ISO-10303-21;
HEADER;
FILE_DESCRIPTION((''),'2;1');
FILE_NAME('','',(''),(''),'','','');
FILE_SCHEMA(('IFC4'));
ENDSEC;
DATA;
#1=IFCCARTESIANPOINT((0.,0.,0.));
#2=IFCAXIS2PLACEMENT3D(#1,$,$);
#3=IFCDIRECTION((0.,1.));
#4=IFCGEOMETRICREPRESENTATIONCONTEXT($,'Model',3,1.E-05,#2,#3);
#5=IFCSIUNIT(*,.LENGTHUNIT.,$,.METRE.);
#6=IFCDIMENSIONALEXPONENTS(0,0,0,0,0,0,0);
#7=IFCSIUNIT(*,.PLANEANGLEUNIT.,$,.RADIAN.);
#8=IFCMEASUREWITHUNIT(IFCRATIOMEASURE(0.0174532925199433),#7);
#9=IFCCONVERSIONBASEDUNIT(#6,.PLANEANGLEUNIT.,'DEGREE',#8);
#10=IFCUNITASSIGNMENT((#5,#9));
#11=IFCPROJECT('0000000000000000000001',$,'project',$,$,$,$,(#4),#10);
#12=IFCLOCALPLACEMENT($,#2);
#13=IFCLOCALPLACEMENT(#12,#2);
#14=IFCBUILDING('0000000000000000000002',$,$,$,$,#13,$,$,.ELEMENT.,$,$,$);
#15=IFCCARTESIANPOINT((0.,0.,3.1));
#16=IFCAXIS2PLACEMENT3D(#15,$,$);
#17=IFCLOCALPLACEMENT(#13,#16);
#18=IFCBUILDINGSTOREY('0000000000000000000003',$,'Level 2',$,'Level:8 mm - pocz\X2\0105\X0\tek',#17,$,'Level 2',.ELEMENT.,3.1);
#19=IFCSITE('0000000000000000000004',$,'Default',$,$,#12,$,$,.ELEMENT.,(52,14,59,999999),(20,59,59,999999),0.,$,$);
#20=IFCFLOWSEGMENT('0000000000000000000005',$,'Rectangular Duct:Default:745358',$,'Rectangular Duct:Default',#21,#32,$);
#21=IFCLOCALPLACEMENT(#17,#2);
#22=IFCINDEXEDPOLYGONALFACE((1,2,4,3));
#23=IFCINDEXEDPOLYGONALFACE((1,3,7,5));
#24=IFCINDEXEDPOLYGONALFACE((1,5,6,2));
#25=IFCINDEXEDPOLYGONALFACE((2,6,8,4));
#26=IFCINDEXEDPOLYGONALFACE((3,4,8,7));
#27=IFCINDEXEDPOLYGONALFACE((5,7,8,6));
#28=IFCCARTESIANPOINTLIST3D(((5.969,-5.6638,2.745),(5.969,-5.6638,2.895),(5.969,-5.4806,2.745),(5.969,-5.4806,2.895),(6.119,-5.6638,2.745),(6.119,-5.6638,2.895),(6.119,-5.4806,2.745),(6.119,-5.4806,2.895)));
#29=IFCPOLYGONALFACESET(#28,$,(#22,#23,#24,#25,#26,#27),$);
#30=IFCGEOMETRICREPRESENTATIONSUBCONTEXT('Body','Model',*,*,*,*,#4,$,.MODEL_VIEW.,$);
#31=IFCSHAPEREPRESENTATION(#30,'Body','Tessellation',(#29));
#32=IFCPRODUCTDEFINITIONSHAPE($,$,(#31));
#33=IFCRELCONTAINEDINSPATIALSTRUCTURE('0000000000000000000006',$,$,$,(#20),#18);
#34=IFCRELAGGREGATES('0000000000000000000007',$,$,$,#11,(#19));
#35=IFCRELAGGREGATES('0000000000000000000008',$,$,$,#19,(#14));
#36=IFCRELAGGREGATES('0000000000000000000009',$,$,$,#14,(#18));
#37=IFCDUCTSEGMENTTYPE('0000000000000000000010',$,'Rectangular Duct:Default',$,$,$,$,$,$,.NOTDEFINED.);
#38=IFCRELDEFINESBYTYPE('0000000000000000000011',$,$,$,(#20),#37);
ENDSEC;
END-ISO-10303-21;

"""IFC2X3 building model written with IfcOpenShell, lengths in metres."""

from ifc_helpers import new_model, entity, si_unit, converted_unit, direction, frame, origin, origin_2d_with_axis, place, context, subcontext, project, spatial, rectangle, extrude, type_object, element, save


model = new_model("IFC2X3")

# Units and contexts
model_context = context("Model", 3, precision=1e-05, world=origin(), true_north=direction((0.0, 1.0)))
body_context = subcontext(model_context, "Body", "Model", "MODEL_VIEW")
ifc_project = project(units=[si_unit("LENGTHUNIT", "METRE"), converted_unit("PLANEANGLEUNIT", "DEGREE", entity("IfcRatioMeasure", 0.0174532925199433), si_unit("PLANEANGLEUNIT", "RADIAN"), dimensions=[0, 0, 0, 0, 0, 0, 0])], contexts=[model_context])

# Site, building, storey
site_placement = place(None, origin())
site = spatial("IfcSite", under=ifc_project, at=site_placement, Name="Default", CompositionType="ELEMENT", RefLatitude=(52, 14, 59, 999999), RefLongitude=(20, 59, 59, 999999), RefElevation=0.0)
building_placement = place(site_placement, origin())
building = spatial("IfcBuilding", under=site, at=building_placement, CompositionType="ELEMENT")
storey_placement = place(building_placement, frame((0.0, 0.0, 3.1)))
storey = spatial("IfcBuildingStorey", under=building, at=storey_placement, Name="Level 2", ObjectType="Level:8 mm - początek", LongName="Level 2", CompositionType="ELEMENT", Elevation=3.1)

# Flow segment
duct_segment_type = type_object("IfcDuctSegmentType", Name="Rectangular Duct:Default", PredefinedType="NOTDEFINED")
flow_segment_1_placement = place(storey_placement, origin())
element("IfcFlowSegment", 1, at=flow_segment_1_placement, inside=storey, type_object=duct_segment_type, Name="Rectangular Duct:Default:745358", ObjectType="Rectangular Duct:Default", context=body_context, shape_type="SweptSolid", body=[
    extrude(rectangle(XDim=0.1832, YDim=0.15, at=origin_2d_with_axis()), frame((6.044, -5.5722, 2.745), z_axis=(0.0, 0.0, 1.0), x_axis=(0.0, 1.0, 0.0)), (0.0, 0.0, 1.0), 0.15),
])

save(model, "model.ifc")
